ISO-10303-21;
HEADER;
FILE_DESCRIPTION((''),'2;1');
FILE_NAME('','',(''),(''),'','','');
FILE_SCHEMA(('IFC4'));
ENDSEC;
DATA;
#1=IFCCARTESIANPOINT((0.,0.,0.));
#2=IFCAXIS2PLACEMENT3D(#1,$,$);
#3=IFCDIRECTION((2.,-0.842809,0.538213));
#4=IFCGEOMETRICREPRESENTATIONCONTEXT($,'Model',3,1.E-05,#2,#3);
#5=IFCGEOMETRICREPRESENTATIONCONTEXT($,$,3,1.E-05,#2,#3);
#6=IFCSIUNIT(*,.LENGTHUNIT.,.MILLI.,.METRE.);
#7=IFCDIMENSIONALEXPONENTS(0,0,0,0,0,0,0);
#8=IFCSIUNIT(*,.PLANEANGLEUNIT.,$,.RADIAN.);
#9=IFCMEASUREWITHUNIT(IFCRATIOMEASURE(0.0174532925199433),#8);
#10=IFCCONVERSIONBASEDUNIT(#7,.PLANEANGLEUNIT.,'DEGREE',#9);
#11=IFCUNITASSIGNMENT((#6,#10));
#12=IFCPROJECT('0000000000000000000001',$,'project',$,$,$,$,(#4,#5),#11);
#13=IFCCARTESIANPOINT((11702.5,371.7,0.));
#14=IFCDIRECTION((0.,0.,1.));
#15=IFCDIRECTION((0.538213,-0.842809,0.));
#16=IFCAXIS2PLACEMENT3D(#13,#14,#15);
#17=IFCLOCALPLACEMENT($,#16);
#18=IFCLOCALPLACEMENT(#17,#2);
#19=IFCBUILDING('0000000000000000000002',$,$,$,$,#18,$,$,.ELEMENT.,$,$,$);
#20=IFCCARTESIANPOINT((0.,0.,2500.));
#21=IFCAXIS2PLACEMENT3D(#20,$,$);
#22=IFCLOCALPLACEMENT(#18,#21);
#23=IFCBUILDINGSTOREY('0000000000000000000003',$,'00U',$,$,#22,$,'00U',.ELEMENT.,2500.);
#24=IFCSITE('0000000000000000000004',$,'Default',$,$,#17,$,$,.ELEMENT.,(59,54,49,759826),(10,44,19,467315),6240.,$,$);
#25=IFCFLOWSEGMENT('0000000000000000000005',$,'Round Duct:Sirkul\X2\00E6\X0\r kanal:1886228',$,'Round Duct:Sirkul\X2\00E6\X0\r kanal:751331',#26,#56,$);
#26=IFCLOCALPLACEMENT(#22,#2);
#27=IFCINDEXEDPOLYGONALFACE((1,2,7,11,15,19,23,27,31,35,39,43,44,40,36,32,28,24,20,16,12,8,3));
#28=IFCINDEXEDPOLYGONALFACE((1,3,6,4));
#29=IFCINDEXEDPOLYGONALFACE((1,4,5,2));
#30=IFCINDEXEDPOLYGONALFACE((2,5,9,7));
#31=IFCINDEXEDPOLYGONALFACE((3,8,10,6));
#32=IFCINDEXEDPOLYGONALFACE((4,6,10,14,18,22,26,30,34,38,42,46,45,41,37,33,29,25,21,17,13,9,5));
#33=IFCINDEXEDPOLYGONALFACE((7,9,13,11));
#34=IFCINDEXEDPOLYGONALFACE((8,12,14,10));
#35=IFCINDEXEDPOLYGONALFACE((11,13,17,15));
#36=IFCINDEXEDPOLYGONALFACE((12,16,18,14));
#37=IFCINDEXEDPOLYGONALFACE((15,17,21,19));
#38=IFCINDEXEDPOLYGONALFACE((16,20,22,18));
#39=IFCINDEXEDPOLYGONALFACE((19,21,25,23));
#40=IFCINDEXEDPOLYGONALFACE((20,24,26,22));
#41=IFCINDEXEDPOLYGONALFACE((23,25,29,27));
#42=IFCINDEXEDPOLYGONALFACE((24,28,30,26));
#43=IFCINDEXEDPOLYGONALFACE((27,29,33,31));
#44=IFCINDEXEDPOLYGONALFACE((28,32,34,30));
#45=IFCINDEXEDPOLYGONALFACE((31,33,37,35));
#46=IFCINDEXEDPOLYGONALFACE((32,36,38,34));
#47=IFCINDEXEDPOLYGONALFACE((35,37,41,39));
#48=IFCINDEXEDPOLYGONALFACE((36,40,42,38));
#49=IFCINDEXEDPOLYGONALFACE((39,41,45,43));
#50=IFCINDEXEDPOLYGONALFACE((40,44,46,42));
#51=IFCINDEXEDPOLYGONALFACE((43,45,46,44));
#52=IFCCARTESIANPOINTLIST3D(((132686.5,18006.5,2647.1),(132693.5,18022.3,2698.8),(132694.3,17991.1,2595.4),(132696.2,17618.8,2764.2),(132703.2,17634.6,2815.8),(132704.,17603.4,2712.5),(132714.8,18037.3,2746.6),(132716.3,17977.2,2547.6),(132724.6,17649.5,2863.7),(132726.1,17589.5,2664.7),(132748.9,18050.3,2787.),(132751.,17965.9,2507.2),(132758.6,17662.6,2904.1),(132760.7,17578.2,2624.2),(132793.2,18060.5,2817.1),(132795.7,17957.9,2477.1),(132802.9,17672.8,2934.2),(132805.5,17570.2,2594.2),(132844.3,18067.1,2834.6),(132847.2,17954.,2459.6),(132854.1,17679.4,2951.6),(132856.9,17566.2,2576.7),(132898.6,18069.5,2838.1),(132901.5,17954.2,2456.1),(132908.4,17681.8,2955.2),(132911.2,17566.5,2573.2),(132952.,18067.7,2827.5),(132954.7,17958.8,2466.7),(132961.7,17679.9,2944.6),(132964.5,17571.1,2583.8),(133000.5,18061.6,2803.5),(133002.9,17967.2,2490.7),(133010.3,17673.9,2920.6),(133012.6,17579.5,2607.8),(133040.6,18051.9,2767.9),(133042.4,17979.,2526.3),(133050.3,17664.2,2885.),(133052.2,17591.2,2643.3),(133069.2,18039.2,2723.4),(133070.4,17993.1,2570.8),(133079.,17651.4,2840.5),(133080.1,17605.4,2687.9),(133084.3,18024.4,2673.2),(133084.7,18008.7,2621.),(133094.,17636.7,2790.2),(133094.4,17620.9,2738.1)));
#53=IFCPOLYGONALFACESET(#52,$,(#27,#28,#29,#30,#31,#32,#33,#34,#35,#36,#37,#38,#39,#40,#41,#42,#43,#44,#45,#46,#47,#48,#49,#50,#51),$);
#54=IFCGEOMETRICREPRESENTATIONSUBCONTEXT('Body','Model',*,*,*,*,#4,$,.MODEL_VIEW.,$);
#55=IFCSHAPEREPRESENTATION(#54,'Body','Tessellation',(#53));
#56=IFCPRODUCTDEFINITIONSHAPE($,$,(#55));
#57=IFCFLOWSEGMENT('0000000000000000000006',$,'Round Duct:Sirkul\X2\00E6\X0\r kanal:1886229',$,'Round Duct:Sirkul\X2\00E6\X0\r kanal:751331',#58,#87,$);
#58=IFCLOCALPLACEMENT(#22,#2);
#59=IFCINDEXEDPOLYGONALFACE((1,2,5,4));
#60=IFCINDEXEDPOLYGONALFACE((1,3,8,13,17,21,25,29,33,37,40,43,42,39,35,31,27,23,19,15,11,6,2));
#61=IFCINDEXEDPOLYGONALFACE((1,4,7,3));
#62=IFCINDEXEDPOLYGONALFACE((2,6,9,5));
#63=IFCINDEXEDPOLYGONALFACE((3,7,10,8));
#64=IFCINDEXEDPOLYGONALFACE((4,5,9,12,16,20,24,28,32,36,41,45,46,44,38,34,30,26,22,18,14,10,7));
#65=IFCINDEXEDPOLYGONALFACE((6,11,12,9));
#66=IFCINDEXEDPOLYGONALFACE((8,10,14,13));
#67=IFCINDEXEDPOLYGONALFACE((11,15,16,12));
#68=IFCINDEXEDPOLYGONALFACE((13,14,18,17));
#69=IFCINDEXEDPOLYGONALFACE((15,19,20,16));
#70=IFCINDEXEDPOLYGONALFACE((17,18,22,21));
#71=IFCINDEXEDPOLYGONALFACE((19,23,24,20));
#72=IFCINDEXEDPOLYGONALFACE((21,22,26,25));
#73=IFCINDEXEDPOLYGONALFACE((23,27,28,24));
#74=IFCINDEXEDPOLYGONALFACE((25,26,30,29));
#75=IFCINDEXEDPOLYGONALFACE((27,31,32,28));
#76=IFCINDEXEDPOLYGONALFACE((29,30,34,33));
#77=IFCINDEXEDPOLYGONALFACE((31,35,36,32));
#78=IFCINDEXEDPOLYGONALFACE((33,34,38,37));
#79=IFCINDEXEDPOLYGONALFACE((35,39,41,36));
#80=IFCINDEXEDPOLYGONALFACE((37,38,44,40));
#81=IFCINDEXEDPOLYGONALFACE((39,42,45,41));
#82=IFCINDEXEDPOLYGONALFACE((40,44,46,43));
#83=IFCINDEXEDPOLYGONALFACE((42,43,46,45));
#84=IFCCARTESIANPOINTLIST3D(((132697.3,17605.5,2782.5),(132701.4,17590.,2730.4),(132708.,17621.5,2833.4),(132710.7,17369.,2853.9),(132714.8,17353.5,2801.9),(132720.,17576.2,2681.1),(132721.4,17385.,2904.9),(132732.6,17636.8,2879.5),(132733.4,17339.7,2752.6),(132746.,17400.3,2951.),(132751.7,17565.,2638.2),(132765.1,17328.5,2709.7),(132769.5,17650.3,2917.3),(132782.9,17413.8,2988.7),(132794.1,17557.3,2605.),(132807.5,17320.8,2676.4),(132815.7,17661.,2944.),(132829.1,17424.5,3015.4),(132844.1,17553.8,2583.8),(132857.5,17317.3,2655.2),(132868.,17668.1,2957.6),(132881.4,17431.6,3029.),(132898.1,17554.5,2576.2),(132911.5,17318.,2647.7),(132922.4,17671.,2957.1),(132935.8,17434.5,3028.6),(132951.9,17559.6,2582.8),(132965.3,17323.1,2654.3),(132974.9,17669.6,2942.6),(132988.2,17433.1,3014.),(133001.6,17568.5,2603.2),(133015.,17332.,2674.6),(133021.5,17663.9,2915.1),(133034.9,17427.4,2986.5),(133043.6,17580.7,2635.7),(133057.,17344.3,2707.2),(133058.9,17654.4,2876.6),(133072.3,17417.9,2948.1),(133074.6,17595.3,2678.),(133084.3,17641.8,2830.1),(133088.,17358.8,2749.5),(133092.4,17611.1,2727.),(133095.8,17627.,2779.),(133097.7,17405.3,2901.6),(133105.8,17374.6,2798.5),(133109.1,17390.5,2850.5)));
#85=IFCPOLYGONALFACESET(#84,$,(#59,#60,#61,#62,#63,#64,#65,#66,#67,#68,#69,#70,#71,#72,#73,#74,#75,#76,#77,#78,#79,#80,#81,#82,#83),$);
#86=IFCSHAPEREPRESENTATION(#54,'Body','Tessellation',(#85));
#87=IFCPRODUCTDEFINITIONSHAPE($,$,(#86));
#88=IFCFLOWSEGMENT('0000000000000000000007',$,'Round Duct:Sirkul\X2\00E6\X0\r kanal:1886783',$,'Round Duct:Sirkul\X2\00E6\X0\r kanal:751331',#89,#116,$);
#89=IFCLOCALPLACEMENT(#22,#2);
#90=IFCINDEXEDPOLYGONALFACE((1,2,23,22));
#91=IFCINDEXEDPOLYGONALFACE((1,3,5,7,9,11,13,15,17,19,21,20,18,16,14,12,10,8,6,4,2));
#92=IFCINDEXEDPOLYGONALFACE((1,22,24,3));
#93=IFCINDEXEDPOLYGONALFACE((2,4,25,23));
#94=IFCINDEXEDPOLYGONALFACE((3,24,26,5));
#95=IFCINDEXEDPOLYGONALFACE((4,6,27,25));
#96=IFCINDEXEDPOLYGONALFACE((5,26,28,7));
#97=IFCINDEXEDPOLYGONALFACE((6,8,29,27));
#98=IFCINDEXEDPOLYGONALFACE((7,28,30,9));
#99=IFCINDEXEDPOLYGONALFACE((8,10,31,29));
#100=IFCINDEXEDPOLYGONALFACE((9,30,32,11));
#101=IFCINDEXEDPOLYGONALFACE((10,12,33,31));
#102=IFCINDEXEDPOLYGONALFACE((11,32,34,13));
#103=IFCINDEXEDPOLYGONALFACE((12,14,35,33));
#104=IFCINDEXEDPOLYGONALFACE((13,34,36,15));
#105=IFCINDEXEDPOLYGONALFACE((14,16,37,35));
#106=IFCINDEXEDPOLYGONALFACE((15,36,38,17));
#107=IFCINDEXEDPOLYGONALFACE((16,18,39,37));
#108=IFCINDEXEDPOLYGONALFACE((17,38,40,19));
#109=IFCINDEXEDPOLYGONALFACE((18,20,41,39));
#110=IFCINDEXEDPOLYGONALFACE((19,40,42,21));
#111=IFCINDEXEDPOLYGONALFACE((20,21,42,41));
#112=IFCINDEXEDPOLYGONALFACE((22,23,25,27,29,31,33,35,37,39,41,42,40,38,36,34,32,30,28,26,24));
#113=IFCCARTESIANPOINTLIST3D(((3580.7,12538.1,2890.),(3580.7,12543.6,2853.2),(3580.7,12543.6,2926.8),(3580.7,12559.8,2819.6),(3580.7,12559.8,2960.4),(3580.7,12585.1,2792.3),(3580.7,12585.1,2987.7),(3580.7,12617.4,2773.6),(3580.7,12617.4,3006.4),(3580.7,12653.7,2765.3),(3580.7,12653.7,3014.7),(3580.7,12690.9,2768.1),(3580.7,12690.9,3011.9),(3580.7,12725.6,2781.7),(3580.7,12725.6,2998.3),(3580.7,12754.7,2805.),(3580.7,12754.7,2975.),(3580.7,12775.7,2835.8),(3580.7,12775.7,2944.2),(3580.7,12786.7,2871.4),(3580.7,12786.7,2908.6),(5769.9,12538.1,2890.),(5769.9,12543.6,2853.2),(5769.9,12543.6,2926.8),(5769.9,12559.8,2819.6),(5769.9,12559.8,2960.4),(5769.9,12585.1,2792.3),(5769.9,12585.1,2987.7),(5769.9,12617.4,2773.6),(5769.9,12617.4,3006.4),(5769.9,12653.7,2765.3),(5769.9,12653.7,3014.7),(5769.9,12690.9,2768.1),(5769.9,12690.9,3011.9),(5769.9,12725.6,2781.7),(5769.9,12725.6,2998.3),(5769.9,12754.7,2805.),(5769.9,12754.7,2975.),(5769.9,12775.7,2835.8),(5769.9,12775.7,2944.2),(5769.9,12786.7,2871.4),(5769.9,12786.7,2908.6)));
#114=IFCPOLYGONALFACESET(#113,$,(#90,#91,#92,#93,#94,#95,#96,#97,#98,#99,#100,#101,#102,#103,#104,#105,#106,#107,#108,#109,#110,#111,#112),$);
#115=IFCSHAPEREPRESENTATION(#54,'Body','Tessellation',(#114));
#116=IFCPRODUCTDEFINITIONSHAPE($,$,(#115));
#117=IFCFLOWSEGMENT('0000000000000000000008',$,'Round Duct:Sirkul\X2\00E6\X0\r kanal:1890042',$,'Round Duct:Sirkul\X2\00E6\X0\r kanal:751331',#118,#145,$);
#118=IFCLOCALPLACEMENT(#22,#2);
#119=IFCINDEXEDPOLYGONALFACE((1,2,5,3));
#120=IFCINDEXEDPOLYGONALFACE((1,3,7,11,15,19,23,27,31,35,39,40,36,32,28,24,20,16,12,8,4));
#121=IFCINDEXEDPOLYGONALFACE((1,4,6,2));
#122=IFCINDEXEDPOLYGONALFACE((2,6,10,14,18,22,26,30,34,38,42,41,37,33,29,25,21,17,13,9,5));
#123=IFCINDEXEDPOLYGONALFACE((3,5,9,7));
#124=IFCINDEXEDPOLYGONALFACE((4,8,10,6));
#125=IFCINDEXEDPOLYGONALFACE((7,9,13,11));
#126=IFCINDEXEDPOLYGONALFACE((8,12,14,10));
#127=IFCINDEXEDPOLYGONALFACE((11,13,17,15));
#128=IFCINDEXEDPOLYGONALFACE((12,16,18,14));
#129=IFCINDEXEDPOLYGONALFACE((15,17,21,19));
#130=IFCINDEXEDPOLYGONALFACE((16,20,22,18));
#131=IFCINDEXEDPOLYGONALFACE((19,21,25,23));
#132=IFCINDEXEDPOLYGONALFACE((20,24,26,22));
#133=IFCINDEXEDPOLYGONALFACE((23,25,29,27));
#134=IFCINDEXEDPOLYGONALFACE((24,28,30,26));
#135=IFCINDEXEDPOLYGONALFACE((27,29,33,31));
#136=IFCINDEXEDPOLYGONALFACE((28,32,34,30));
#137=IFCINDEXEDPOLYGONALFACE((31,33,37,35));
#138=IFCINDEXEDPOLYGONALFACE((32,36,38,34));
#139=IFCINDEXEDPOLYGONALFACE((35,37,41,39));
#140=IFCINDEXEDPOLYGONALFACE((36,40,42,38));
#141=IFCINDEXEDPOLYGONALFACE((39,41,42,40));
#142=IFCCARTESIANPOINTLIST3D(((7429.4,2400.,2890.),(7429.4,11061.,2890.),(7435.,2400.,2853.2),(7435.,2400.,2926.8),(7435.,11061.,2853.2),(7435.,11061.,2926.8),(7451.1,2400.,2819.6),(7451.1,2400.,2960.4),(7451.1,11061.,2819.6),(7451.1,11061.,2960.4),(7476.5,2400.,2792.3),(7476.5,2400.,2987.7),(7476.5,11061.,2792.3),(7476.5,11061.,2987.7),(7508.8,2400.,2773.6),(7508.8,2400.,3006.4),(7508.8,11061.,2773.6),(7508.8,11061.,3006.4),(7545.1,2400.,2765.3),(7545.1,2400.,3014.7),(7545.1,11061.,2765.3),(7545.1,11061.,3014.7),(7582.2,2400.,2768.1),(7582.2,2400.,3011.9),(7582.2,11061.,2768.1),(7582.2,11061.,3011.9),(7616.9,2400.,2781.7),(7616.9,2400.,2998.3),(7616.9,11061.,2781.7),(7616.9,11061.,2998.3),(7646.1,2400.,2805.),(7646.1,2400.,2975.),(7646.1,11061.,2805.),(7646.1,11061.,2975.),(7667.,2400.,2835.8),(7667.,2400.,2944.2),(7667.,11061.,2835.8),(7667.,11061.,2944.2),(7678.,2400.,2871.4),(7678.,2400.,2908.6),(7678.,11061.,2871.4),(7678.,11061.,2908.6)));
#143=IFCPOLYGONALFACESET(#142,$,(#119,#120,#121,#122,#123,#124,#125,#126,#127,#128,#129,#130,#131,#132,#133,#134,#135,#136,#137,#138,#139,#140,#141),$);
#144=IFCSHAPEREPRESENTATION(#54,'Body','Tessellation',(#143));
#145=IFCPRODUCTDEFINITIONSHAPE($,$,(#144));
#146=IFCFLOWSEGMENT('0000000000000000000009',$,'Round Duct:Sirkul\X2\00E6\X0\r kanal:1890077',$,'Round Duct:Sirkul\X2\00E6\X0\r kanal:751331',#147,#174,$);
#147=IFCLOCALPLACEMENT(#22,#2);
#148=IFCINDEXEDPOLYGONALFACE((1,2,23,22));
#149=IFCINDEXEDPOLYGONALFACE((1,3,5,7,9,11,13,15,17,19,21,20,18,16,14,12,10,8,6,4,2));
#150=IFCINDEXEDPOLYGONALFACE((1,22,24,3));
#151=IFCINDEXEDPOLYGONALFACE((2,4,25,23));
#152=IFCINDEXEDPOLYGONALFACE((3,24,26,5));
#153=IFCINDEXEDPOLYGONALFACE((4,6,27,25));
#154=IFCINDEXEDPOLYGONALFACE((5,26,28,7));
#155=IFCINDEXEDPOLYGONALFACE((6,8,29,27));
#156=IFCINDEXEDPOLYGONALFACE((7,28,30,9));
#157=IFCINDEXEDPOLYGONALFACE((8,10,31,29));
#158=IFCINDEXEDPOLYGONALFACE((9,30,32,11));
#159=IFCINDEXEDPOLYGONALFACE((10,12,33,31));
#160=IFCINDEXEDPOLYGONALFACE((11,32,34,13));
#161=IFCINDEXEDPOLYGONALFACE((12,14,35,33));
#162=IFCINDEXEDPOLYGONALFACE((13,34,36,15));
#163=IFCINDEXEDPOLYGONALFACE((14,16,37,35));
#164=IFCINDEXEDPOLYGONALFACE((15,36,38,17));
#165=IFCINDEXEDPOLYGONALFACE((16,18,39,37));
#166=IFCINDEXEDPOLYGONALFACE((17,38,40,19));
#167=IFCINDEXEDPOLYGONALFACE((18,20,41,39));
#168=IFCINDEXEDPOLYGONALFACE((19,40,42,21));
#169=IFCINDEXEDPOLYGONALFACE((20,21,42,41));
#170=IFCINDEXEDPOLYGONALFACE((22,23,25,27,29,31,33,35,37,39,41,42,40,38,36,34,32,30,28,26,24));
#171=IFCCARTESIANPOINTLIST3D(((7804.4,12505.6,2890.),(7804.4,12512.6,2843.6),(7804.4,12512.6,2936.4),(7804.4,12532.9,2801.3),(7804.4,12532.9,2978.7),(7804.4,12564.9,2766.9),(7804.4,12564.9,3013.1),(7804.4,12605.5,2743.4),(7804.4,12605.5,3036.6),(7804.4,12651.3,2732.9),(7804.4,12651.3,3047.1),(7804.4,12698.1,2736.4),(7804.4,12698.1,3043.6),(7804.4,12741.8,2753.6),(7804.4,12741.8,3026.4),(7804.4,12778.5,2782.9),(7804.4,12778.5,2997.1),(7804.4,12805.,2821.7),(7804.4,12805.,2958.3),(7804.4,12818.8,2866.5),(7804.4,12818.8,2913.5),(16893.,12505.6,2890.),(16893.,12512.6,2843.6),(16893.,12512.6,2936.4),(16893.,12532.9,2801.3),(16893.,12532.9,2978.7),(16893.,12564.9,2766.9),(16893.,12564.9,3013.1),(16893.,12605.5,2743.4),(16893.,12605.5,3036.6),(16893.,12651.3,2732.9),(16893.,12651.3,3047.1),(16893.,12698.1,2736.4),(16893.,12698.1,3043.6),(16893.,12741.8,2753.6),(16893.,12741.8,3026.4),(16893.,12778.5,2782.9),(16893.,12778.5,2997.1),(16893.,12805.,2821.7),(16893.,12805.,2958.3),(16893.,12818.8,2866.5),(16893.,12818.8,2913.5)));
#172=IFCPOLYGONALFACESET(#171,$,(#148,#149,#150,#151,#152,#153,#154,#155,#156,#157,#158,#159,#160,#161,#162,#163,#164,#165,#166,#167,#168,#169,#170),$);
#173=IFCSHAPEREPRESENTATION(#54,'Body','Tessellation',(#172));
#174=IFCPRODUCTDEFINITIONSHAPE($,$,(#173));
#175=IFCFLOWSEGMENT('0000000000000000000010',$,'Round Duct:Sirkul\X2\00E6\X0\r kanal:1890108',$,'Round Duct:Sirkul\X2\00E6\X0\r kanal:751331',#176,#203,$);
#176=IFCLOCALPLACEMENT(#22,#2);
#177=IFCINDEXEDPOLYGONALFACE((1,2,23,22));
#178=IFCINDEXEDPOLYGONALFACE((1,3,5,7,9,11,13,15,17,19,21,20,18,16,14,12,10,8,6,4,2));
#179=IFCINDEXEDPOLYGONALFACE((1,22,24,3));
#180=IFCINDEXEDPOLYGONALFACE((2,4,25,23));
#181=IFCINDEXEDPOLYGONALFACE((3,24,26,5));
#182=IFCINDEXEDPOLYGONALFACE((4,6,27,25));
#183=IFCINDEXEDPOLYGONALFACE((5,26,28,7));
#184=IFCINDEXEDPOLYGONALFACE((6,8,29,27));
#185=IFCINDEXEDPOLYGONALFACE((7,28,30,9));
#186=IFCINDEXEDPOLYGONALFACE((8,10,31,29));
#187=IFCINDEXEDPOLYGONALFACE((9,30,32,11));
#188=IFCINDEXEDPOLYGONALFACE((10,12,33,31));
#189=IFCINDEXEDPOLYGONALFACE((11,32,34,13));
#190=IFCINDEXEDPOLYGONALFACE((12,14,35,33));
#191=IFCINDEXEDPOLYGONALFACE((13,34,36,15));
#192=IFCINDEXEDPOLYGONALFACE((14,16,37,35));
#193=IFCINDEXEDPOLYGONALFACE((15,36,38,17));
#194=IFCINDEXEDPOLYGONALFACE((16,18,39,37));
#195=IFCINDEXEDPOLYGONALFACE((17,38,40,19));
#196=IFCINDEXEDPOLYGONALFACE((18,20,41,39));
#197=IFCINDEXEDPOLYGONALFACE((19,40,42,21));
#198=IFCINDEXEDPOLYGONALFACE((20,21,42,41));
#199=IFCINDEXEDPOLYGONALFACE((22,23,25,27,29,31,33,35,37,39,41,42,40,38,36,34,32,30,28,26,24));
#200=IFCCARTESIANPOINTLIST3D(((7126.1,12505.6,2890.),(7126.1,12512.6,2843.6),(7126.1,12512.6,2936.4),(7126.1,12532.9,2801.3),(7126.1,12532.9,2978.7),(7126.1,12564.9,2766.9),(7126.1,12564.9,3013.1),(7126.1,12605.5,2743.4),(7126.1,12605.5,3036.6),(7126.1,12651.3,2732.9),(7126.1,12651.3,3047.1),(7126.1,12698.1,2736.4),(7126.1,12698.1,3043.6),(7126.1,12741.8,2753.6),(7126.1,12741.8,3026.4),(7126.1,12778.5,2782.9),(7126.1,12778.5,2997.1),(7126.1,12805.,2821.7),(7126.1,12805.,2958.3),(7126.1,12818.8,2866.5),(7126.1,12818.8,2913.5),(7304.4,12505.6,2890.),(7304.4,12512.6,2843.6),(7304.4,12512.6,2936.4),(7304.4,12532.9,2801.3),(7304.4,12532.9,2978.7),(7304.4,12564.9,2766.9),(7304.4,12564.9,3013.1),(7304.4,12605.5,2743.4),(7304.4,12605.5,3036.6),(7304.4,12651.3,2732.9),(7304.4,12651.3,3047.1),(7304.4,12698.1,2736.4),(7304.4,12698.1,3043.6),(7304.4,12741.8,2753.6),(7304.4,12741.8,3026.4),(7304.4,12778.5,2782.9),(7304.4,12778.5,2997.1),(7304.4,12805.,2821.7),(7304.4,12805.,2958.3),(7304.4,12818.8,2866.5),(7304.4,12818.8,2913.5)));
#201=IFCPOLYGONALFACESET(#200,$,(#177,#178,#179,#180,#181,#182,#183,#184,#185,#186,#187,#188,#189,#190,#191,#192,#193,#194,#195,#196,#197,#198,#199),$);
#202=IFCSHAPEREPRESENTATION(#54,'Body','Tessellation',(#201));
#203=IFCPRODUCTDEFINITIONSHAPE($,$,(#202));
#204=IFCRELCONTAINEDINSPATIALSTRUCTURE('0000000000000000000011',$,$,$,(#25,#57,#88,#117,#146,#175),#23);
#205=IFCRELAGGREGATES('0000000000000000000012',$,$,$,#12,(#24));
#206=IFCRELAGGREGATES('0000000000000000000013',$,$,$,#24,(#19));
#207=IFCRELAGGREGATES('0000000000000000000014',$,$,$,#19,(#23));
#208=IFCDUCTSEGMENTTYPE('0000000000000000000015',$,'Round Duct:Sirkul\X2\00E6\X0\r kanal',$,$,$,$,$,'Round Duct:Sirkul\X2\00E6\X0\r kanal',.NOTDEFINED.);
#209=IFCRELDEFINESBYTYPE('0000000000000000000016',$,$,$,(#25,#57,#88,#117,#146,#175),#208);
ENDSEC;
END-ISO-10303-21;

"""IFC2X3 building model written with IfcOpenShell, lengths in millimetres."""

from ifc_helpers import new_model, entity, si_unit, converted_unit, direction, frame, frame_2d, origin, origin_2d_with_axis, place, context, subcontext, project, spatial, circle, extrude, type_object, element, save


model = new_model("IFC2X3")

# Units and contexts
model_context = context("Model", 3, precision=1e-05, world=origin(), true_north=direction((2.0, -0.842809, 0.538213)))
context_of_model = context(None, 3, precision=1e-05, world=origin(), true_north=direction((2.0, -0.842809, 0.538213)))
body_context = subcontext(model_context, "Body", "Model", "MODEL_VIEW")
ifc_project = project(units=[si_unit("LENGTHUNIT", "METRE", prefix="MILLI"), converted_unit("PLANEANGLEUNIT", "DEGREE", entity("IfcRatioMeasure", 0.0174532925199433), si_unit("PLANEANGLEUNIT", "RADIAN"), dimensions=[0, 0, 0, 0, 0, 0, 0])], contexts=[model_context, context_of_model])

# Site, building, storey
site_placement = place(None, frame((11702.5, 371.7, 0.0), z_axis=(0.0, 0.0, 1.0), x_axis=(0.538213, -0.842809, 0.0)))
site = spatial("IfcSite", under=ifc_project, at=site_placement, Name="Default", CompositionType="ELEMENT", RefLatitude=(59, 54, 49, 759826), RefLongitude=(10, 44, 19, 467315), RefElevation=6240.0)
building_placement = place(site_placement, origin())
building = spatial("IfcBuilding", under=site, at=building_placement, CompositionType="ELEMENT")
storey_placement = place(building_placement, frame((0.0, 0.0, 2500.0)))
storey = spatial("IfcBuildingStorey", under=building, at=storey_placement, Name="00U", LongName="00U", CompositionType="ELEMENT", Elevation=2500.0)

# Flow segments
duct_segment_type_1 = type_object("IfcDuctSegmentType", Name="Round Duct:Sirkulær kanal", ElementType="Round Duct:Sirkulær kanal", PredefinedType="NOTDEFINED")
flow_segment_1_placement = place(storey_placement, origin())
element("IfcFlowSegment", 1, at=flow_segment_1_placement, inside=storey, type_object=duct_segment_type_1, Name="Round Duct:Sirkulær kanal:1886228", ObjectType="Round Duct:Sirkulær kanal:751331", context=body_context, shape_type="SweptSolid", body=[
    extrude(circle(Radius=200.0, at=frame_2d((0.0, 0.0), x_axis=(1.0, 0.0))), frame((132896.2, 17623.8, 2764.2), z_axis=(-0.024023, 0.957033, -0.288983), x_axis=(-0.999685, -0.025094, 0.0)), (0.0, 0.0, 1.0), 405.1),
])
flow_segment_2_placement = place(storey_placement, origin())
element("IfcFlowSegment", 2, at=flow_segment_2_placement, inside=storey, type_object=duct_segment_type_1, Name="Round Duct:Sirkulær kanal:1886229", ObjectType="Round Duct:Sirkulær kanal:751331", context=body_context, shape_type="SweptSolid", body=[
    extrude(circle(Radius=200.0, at=frame_2d((0.0, 0.0), x_axis=(1.0, 0.0))), frame((132896.6, 17612.3, 2767.7), z_axis=(0.054095, -0.955844, 0.288853), x_axis=(0.007252, -0.288892, -0.957334)), (0.0, 0.0, 1.0), 247.4),
])
flow_segment_3_placement = place(storey_placement, origin())
element("IfcFlowSegment", 3, at=flow_segment_3_placement, inside=storey, type_object=duct_segment_type_1, Name="Round Duct:Sirkulær kanal:1886783", ObjectType="Round Duct:Sirkulær kanal:751331", context=body_context, shape_type="SweptSolid", body=[
    extrude(circle(Radius=125.0, at=origin_2d_with_axis()), frame((3580.7, 12663.1, 2890.0), z_axis=(1.0, 0.0, 0.0), x_axis=(0.0, -1.0, 0.0)), (0.0, 0.0, 1.0), 2189.2),
])
flow_segment_4_placement = place(storey_placement, origin())
element("IfcFlowSegment", 4, at=flow_segment_4_placement, inside=storey, type_object=duct_segment_type_1, Name="Round Duct:Sirkulær kanal:1890042", ObjectType="Round Duct:Sirkulær kanal:751331", context=body_context, shape_type="SweptSolid", body=[
    extrude(circle(Radius=125.0, at=frame_2d((0.0, 0.0), x_axis=(1.0, 0.0))), frame((7554.4, 2400.0, 2890.0), z_axis=(0.0, 1.0, 0.0), x_axis=(-1.0, 0.0, 0.0)), (0.0, 0.0, 1.0), 8661.0),
])
flow_segment_5_placement = place(storey_placement, origin())
element("IfcFlowSegment", 5, at=flow_segment_5_placement, inside=storey, type_object=duct_segment_type_1, Name="Round Duct:Sirkulær kanal:1890077", ObjectType="Round Duct:Sirkulær kanal:751331", context=body_context, shape_type="SweptSolid", body=[
    extrude(circle(Radius=157.5, at=origin_2d_with_axis()), frame((7804.4, 12663.1, 2890.0), z_axis=(1.0, 0.0, 0.0), x_axis=(0.0, -1.0, 0.0)), (0.0, 0.0, 1.0), 9088.6),
])
flow_segment_6_placement = place(storey_placement, origin())
element("IfcFlowSegment", 6, at=flow_segment_6_placement, inside=storey, type_object=duct_segment_type_1, Name="Round Duct:Sirkulær kanal:1890108", ObjectType="Round Duct:Sirkulær kanal:751331", context=body_context, shape_type="SweptSolid", body=[
    extrude(circle(Radius=157.5, at=origin_2d_with_axis()), frame((7126.1, 12663.1, 2890.0), z_axis=(1.0, 0.0, 0.0), x_axis=(0.0, -1.0, 0.0)), (0.0, 0.0, 1.0), 178.3),
])

save(model, "model.ifc")
